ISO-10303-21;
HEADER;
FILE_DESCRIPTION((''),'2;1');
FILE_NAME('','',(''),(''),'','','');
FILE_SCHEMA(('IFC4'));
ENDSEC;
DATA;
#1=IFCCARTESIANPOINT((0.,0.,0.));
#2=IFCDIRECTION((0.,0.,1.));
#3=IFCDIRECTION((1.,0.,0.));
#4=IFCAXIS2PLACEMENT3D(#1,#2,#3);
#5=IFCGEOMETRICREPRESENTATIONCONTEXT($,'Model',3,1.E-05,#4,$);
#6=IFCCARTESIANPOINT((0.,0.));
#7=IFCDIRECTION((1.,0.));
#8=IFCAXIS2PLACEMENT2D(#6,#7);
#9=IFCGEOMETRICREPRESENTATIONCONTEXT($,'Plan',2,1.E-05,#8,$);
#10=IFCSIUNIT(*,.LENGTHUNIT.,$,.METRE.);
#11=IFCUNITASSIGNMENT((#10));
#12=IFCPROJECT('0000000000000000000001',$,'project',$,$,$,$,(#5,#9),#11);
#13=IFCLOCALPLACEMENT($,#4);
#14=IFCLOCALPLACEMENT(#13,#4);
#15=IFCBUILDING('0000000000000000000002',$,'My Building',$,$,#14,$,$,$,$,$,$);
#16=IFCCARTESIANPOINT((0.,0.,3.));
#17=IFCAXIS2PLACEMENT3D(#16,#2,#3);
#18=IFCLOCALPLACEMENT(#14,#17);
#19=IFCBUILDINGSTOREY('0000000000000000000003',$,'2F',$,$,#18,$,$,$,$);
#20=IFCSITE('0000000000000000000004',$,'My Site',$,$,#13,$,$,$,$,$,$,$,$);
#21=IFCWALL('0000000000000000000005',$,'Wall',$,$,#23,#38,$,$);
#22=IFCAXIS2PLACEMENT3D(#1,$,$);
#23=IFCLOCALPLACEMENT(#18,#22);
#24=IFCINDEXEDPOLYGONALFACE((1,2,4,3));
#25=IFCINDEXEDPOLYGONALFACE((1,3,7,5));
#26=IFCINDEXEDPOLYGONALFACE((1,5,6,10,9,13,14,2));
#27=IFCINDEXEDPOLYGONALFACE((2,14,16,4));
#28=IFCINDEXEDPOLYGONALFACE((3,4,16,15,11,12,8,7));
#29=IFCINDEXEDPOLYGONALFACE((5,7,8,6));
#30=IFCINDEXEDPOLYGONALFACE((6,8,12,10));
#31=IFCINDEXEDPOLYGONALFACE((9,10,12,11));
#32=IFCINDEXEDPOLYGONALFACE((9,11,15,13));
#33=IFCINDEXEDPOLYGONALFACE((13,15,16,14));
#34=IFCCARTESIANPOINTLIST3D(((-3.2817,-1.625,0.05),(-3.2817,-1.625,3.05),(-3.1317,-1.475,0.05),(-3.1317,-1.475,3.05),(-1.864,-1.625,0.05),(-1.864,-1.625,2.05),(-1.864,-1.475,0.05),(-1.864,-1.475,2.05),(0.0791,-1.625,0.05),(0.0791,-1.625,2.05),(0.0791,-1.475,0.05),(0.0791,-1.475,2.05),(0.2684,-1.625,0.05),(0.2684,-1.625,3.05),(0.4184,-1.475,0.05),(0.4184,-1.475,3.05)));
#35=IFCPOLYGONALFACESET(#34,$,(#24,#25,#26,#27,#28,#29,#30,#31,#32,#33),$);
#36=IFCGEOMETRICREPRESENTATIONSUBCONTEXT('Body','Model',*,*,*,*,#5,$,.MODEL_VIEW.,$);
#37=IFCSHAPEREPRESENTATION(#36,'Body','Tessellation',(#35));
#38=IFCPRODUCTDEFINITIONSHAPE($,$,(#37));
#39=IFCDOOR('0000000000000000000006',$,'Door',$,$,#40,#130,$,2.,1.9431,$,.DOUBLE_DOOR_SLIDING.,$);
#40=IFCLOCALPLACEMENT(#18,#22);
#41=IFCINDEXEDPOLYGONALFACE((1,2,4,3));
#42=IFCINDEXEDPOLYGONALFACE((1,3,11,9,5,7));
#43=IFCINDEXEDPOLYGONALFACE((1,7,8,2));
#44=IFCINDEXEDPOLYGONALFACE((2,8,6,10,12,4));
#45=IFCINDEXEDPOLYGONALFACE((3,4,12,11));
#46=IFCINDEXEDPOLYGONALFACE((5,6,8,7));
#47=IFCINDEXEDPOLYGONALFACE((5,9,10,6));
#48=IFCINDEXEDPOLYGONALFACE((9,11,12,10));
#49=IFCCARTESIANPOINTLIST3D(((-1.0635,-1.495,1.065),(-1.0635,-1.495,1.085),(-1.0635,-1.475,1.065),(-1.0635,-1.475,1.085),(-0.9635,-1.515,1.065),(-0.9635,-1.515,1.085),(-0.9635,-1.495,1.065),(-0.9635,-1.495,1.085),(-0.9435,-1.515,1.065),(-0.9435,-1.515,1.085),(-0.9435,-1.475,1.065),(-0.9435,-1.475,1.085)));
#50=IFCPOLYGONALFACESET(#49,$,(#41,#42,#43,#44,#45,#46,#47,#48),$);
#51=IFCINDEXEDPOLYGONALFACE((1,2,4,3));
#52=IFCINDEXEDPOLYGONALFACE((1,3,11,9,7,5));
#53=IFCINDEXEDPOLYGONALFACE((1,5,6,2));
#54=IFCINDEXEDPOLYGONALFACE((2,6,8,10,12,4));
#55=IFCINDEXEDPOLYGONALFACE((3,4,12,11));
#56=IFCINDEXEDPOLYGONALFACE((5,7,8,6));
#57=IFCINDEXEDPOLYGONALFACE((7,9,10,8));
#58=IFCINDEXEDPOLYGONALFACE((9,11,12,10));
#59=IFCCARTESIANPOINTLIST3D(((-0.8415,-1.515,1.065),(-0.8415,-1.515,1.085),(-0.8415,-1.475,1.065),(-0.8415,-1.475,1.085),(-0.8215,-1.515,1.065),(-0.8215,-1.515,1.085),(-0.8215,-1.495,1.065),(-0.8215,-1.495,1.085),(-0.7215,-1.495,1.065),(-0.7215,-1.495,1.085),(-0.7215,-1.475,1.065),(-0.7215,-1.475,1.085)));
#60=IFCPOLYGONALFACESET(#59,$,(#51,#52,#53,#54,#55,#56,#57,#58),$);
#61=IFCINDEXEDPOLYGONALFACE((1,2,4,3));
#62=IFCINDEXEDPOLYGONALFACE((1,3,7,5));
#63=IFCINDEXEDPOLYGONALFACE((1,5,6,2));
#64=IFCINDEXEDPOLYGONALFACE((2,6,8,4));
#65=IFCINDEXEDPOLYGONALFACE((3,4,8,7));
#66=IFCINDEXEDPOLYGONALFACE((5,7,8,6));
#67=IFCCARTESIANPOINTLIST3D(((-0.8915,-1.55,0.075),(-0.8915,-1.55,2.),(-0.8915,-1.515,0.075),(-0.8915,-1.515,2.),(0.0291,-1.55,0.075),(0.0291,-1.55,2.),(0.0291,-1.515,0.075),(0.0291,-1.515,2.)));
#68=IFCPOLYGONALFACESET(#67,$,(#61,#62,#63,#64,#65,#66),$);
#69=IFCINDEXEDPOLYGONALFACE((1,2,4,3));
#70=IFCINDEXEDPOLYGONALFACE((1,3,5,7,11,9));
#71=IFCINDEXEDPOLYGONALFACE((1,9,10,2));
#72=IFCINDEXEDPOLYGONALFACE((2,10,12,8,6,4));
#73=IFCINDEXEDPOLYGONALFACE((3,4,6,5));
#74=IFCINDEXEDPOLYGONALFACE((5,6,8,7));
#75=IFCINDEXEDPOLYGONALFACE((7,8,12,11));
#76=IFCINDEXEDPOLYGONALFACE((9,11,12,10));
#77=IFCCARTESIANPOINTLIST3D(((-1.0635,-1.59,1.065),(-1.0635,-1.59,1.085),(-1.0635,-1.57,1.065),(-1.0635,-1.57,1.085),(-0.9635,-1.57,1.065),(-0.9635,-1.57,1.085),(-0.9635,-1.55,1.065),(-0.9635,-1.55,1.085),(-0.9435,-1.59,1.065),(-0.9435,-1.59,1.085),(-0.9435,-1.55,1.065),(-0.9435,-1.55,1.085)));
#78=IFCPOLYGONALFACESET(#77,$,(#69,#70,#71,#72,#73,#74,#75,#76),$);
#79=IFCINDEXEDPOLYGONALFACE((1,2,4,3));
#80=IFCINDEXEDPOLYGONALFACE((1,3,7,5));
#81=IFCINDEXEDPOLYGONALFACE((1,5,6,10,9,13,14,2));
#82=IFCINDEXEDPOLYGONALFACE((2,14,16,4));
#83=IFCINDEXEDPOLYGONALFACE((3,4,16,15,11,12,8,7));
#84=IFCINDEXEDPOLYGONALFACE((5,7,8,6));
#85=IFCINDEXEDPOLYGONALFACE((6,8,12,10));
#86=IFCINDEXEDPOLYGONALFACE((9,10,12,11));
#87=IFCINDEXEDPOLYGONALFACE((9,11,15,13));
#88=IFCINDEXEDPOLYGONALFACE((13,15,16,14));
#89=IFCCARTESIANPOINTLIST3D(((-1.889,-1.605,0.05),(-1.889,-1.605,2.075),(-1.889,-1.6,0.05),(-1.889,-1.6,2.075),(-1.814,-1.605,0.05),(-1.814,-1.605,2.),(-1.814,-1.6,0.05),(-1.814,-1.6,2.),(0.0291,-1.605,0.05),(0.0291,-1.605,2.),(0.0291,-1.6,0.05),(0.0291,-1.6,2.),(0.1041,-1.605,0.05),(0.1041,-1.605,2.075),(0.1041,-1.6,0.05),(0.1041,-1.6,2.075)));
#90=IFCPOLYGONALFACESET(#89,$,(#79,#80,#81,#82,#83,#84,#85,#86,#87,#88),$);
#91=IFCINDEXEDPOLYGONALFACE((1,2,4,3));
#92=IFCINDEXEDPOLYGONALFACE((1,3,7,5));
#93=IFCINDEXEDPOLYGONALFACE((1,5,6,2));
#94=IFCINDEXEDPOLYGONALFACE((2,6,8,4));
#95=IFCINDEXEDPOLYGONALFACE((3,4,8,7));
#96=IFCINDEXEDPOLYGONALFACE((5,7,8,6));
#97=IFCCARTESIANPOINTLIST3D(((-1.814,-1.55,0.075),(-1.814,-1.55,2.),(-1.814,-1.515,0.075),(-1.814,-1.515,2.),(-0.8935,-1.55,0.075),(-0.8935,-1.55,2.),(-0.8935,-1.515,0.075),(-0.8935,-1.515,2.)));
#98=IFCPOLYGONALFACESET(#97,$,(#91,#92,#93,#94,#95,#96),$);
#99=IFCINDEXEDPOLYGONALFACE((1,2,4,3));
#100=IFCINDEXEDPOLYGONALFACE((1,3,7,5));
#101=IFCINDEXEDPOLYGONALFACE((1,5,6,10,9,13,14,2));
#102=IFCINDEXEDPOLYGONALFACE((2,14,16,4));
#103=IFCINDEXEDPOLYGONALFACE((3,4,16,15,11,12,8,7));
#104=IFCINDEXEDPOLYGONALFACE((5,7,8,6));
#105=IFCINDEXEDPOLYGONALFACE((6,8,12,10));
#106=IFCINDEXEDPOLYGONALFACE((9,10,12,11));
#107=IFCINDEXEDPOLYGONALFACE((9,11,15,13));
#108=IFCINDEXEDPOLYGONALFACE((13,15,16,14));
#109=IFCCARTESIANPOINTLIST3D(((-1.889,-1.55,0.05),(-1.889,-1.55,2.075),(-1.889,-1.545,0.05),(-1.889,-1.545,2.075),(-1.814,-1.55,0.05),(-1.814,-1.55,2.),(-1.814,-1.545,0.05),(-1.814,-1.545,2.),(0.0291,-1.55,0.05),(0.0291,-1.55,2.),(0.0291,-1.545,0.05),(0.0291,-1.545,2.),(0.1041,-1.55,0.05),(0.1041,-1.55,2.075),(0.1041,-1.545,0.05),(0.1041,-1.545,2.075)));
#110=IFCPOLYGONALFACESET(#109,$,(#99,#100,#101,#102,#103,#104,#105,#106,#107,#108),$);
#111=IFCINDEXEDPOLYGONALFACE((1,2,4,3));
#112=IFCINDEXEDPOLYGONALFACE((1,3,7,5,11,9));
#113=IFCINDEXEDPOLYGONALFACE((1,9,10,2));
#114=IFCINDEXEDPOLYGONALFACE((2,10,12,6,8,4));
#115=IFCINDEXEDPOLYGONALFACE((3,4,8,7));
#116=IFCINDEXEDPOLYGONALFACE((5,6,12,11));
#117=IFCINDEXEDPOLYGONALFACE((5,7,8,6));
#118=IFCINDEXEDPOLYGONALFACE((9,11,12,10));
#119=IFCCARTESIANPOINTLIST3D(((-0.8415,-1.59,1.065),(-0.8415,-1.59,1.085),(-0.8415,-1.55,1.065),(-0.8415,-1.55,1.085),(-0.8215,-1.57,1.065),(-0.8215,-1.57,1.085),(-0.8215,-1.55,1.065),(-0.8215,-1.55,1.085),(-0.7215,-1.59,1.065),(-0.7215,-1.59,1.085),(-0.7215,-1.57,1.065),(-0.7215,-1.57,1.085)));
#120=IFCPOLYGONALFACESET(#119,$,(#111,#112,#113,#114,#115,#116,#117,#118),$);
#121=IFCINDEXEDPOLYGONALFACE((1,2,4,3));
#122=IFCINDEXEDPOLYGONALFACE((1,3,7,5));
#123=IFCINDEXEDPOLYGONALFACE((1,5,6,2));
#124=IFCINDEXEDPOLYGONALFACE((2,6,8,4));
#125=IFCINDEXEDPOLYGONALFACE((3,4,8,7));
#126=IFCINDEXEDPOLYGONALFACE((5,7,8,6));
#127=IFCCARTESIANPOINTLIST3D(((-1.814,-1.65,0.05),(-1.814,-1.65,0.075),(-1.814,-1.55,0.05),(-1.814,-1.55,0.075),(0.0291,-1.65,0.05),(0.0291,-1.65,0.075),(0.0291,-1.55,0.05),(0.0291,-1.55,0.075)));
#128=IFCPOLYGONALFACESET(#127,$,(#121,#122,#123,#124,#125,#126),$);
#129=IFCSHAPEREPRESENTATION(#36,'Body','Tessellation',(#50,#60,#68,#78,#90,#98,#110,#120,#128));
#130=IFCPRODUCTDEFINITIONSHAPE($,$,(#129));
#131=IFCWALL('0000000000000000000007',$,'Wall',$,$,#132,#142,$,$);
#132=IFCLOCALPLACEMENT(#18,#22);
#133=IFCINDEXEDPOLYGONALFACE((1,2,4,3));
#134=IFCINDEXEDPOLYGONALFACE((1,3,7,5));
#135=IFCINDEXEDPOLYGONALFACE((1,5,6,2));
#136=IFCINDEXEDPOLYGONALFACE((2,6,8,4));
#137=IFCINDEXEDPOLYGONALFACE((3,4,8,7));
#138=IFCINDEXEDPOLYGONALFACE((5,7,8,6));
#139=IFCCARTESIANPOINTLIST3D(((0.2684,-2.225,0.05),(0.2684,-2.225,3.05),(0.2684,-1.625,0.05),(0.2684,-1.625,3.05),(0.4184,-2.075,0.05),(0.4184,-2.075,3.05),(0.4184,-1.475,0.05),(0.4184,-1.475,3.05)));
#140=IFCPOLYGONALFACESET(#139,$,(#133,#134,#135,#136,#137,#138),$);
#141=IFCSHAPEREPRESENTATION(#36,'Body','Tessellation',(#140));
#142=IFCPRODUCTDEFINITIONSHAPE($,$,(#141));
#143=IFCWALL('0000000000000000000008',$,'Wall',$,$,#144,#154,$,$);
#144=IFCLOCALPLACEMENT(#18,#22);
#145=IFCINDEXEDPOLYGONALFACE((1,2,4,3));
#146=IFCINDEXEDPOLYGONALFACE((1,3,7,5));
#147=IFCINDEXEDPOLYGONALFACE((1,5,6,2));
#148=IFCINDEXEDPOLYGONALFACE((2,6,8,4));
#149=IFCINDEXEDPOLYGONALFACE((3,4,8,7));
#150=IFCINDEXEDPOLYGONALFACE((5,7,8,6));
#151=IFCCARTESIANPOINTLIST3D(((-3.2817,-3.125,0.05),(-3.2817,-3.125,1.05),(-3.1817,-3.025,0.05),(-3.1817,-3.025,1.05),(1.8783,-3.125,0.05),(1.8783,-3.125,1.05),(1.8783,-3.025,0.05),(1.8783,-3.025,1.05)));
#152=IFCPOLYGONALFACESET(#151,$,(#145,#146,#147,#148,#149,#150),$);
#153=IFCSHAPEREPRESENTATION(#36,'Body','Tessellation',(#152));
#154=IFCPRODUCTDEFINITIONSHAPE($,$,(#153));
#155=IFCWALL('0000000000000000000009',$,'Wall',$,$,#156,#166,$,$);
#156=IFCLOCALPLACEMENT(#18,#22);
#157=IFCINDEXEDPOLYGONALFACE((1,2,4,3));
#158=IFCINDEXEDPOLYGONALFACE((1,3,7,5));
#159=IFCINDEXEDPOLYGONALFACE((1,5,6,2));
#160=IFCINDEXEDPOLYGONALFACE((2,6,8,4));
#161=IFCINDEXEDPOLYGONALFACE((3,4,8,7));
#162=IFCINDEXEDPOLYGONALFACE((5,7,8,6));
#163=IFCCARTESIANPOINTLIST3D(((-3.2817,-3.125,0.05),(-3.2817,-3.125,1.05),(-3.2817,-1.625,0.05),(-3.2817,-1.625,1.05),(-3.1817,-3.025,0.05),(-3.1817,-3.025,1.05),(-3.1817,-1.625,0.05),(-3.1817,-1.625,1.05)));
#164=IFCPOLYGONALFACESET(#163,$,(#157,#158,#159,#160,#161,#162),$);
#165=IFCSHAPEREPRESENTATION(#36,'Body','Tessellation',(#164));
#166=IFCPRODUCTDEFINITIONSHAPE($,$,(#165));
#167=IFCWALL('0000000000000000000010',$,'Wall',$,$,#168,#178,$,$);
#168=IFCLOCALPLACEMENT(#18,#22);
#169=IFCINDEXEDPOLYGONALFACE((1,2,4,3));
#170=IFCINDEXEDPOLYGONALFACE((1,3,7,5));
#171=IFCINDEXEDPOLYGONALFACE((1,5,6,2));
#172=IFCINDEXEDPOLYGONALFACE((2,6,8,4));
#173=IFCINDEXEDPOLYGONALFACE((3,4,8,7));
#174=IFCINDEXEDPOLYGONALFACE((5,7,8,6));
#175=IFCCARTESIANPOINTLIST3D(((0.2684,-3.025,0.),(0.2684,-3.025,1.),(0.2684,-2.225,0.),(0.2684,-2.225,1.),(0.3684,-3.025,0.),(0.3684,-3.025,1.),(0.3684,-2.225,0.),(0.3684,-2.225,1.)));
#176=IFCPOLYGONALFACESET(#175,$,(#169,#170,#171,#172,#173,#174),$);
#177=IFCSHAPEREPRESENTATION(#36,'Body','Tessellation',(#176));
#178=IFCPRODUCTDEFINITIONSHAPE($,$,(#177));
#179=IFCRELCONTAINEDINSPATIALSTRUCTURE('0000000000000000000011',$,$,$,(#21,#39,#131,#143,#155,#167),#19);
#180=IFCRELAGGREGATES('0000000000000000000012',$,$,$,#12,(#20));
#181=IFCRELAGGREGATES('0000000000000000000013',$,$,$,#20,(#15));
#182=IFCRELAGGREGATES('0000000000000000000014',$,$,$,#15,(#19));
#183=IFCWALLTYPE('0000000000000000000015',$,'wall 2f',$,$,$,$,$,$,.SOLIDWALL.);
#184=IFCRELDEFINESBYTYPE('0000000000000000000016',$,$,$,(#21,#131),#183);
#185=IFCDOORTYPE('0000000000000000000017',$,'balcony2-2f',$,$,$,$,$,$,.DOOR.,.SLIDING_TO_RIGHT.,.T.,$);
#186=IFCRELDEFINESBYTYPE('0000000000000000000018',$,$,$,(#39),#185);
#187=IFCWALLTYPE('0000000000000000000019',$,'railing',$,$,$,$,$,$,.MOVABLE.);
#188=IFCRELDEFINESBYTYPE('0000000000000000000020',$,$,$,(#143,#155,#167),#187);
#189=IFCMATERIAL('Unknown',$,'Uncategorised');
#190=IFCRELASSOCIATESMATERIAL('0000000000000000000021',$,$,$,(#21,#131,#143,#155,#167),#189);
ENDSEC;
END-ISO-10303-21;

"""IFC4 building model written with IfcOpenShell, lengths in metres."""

from ifc_helpers import new_model, entity, si_unit, frame, origin_with_axes, origin_2d_with_axis, place, context, subcontext, project, spatial, line, indexed_curve, outline, extrude, shape, source, transform, mapped, material, type_object, type_shapes, element, fill, save


model = new_model("IFC4")

# Units and contexts
model_context = context("Model", 3, precision=1e-05, world=origin_with_axes())
plan_context = context("Plan", 2, precision=1e-05, world=origin_2d_with_axis())
body_context_1 = subcontext(model_context, "Body", "Model", "MODEL_VIEW")
body_context_2 = subcontext(plan_context, "Body", "Plan", "PLAN_VIEW")
ifc_project = project(units=[si_unit("LENGTHUNIT", "METRE")], contexts=[model_context, plan_context])

# Site, building, storey
site_placement = place(None, origin_with_axes())
site = spatial("IfcSite", under=ifc_project, at=site_placement, Name="My Site")
building_placement = place(site_placement, origin_with_axes())
building = spatial("IfcBuilding", under=site, at=building_placement, Name="My Building")
storey_placement = place(building_placement, frame((0.0, 0.0, 3.0), z_axis=(0.0, 0.0, 1.0), x_axis=(1.0, 0.0, 0.0)))
storey = spatial("IfcBuildingStorey", under=building, at=storey_placement, Name="2F")

# Shared definitions
ifc_material = material(Name="Unknown", Category="Uncategorised")

# Shared definitions
wall_type_1 = type_object("IfcWallType", Name="wall 2f", PredefinedType="SOLIDWALL")

# Wall, opening, door
wall_1_placement = place(storey_placement, frame((-3.2817, -1.625, 0.05), z_axis=(0.0, 0.0, 1.0), x_axis=(1.0, 0.0, 0.0)))
wall_1 = element("IfcWall", 1, at=wall_1_placement, inside=storey, type_object=wall_type_1, material=ifc_material, Name="Wall", context=body_context_1, shape_type="SweptSolid", body=[
    extrude(outline(indexed_curve([(0.0, 0.0), (0.15, 0.15), (3.7, 0.15), (3.55, 0.0)], segments=[line(1, 2, 3, 4, 1)])), origin_with_axes(), (0.0, 0.0, 1.0), 3.0),
])
shared_shape_1 = source(origin_with_axes(), body_context_1, "Body", "SweptSolid", [
    extrude(outline(indexed_curve([(0.0, 0.0), (1.9431, 0.0), (1.9431, 2.0), (0.0, 2.0)], segments=[line(1, 2, 3, 4, 1)])), frame((0.0, -0.6, 0.0), z_axis=(0.0, -1.0, 0.0), x_axis=(1.0, 0.0, 0.0)), (0.0, 0.0, -1.0), 1.2),
])
opening_1_placement = place(wall_1_placement, frame((3.3607, 0.075, 0.0), z_axis=(0.0, 0.0, 1.0), x_axis=(-1.0, 0.0, 0.0)))
opening_1 = element("IfcOpeningElement", 2, at=opening_1_placement, cuts=wall_1, PredefinedType="OPENING", context=body_context_1, shape_type="MappedRepresentation", body=[
    mapped(shared_shape_1, transform((0.0, 0.0, 0.0), x_axis=(1.0, 0.0, 0.0), y_axis=(0.0, 1.0, 0.0), z_axis=(0.0, 0.0, 1.0), scale=1.0)),
])
door_type_1 = type_object("IfcDoorType", Name="balcony2-2f", OperationType="SLIDING_TO_RIGHT", ParameterTakesPrecedence=True, PredefinedType="DOOR")
shared_shape_2 = source(origin_with_axes(), body_context_1, "Body", "SweptSolid", [
    extrude(outline(indexed_curve([(0.0, 0.0), (0.0, -0.04), (0.12, -0.04), (0.12, -0.02), (0.02, -0.02), (0.02, 0.0)], segments=[line(1, 2, 3, 4, 5, 6, 1)])), frame((1.0225, -0.035, 1.015), z_axis=(0.0, 0.0, 1.0), x_axis=(1.0, 0.0, 0.0)), (0.0, 0.0, 1.0), 0.02),
    extrude(outline(indexed_curve([(0.0, 0.0), (0.0, -0.04), (-0.12, -0.04), (-0.12, -0.02), (-0.02, -0.02), (-0.02, 0.0)], segments=[line(1, 2, 3, 4, 5, 6, 1)])), frame((0.9205, -0.035, 1.015), z_axis=(0.0, 0.0, 1.0), x_axis=(1.0, 0.0, 0.0)), (0.0, 0.0, 1.0), 0.02),
    extrude(outline(indexed_curve([(0.0, 0.0), (0.9205, 0.0), (0.9205, 0.035), (0.0, 0.035)], segments=[line(1, 2, 3, 4, 1)])), frame((0.05, -0.035, 0.025), z_axis=(0.0, 0.0, 1.0), x_axis=(1.0, 0.0, 0.0)), (0.0, 0.0, 1.0), 1.925),
    extrude(outline(indexed_curve([(0.0, 0.0), (0.0, 0.04), (0.12, 0.04), (0.12, 0.02), (0.02, 0.02), (0.02, 0.0)], segments=[line(1, 2, 3, 4, 5, 6, 1)])), frame((1.0225, 0.0, 1.015), z_axis=(0.0, 0.0, 1.0), x_axis=(1.0, 0.0, 0.0)), (0.0, 0.0, 1.0), 0.02),
    extrude(outline(indexed_curve([(0.0, 0.0), (0.0, 2.025), (1.9931, 2.025), (1.9931, 0.0), (1.9181, 0.0), (1.9181, 1.95), (0.075, 1.95), (0.075, 0.0)], segments=[line(1, 2, 3, 4, 5, 6, 7, 8, 1)])), frame((-0.025, 0.05, 0.0), z_axis=(0.0, -1.0, 0.0), x_axis=(1.0, 0.0, 0.0)), (0.0, 0.0, -1.0), 0.005),
    extrude(outline(indexed_curve([(0.0, 0.0), (-0.9205, 0.0), (-0.9205, 0.035), (0.0, 0.035)], segments=[line(1, 2, 3, 4, 1)])), frame((1.8931, -0.035, 0.025), z_axis=(0.0, 0.0, 1.0), x_axis=(1.0, 0.0, 0.0)), (0.0, 0.0, 1.0), 1.925),
    extrude(outline(indexed_curve([(0.0, 0.0), (0.0, 2.025), (1.9931, 2.025), (1.9931, 0.0), (1.9181, 0.0), (1.9181, 1.95), (0.075, 1.95), (0.075, 0.0)], segments=[line(1, 2, 3, 4, 5, 6, 7, 8, 1)])), frame((-0.025, -0.005, 0.0), z_axis=(0.0, -1.0, 0.0), x_axis=(1.0, 0.0, 0.0)), (0.0, 0.0, -1.0), 0.005),
    extrude(outline(indexed_curve([(0.0, 0.0), (0.0, 0.04), (-0.12, 0.04), (-0.12, 0.02), (-0.02, 0.02), (-0.02, 0.0)], segments=[line(1, 2, 3, 4, 5, 6, 1)])), frame((0.9205, 0.0, 1.015), z_axis=(0.0, 0.0, 1.0), x_axis=(1.0, 0.0, 0.0)), (0.0, 0.0, 1.0), 0.02),
    extrude(outline(indexed_curve([(0.0, 0.0), (1.8431, 0.0), (1.8431, 0.1), (0.0, 0.1)], segments=[line(1, 2, 3, 4, 1)])), frame((0.05, 0.0, 0.0), z_axis=(0.0, 0.0, 1.0), x_axis=(1.0, 0.0, 0.0)), (0.0, 0.0, 1.0), 0.025),
])
shared_shape_3 = source(origin_with_axes(), body_context_2, "Body", "Curve2D", [
    entity("IfcIndexedPolyCurve", entity("IfcCartesianPointList2D", [[0.0, 0.0], [0.05, 0.0], [0.05, 0.05], [0.0, 0.05]]), [entity("IfcLineIndex", [1, 2, 3, 4, 1])]),
    entity("IfcIndexedPolyCurve", entity("IfcCartesianPointList2D", [[1.9431, 0.0], [1.8931, 0.0], [1.8931, 0.05], [1.9431, 0.05]]), [entity("IfcLineIndex", [1, 2, 3, 4, 1])]),
    entity("IfcIndexedPolyCurve", entity("IfcCartesianPointList2D", [[-0.4108, -0.035], [0.5108, -0.035], [0.5108, 0.0], [-0.4108, 0.0]]), [entity("IfcLineIndex", [1, 2, 3, 4, 1])]),
    entity("IfcIndexedPolyCurve", entity("IfcCartesianPointList2D", [[2.3538, -0.035], [1.4323, -0.035], [1.4323, 0.0], [2.3538, 0.0]]), [entity("IfcLineIndex", [1, 2, 3, 4, 1])]),
])
type_shapes(door_type_1, [shared_shape_2, shared_shape_3])
door_1_placement = place(opening_1_placement, origin_with_axes())
door_1 = element("IfcDoor", 3, at=door_1_placement, inside=storey, type_object=door_type_1, Name="Door", OperationType="DOUBLE_DOOR_SLIDING", OverallHeight=2.0, OverallWidth=1.9431, shapes=[
    shape(body_context_1, "Body", "MappedRepresentation", [mapped(shared_shape_2, transform((0.0, 0.0, 0.0), x_axis=(1.0, 0.0, 0.0), y_axis=(0.0, 1.0, 0.0), z_axis=(0.0, 0.0, 1.0), scale=1.0))]),
    shape(body_context_2, "Body", "MappedRepresentation", [mapped(shared_shape_3, transform((0.0, 0.0, 0.0), x_axis=(1.0, 0.0, 0.0), y_axis=(0.0, 1.0, 0.0), z_axis=(0.0, 0.0, 1.0), scale=1.0))]),
])
fill(opening_1, door_1)

# Walls
wall_2_placement = place(storey_placement, frame((0.2684, -1.625, 0.05), z_axis=(0.0, 0.0, 1.0), x_axis=(0.0, -1.0, 0.0)))
element("IfcWall", 4, at=wall_2_placement, inside=storey, type_object=wall_type_1, material=ifc_material, Name="Wall", context=body_context_1, shape_type="SweptSolid", body=[
    extrude(outline(indexed_curve([(0.0, 0.0), (-0.15, 0.15), (0.45, 0.15), (0.6, 0.0)], segments=[line(1, 2, 3, 4, 1)])), origin_with_axes(), (0.0, 0.0, 1.0), 3.0),
])
wall_type_2 = type_object("IfcWallType", Name="railing", PredefinedType="MOVABLE")
wall_3_placement = place(storey_placement, frame((1.8783, -3.025, 0.05), z_axis=(0.0, 0.0, 1.0), x_axis=(-1.0, 0.0, 0.0)))
element("IfcWall", 5, at=wall_3_placement, inside=storey, type_object=wall_type_2, material=ifc_material, Name="Wall", context=body_context_1, shape_type="SweptSolid", body=[
    extrude(outline(indexed_curve([(0.0, 0.0), (0.0, 0.1), (5.16, 0.1), (5.06, 0.0)], segments=[line(1, 2, 3, 4, 1)])), origin_with_axes(), (0.0, 0.0, 1.0), 1.0),
])
wall_4_placement = place(storey_placement, frame((-3.2817, -1.625, 0.05), z_axis=(0.0, 0.0, 1.0), x_axis=(0.0, -1.0, 0.0)))
element("IfcWall", 6, at=wall_4_placement, inside=storey, type_object=wall_type_2, material=ifc_material, Name="Wall", context=body_context_1, shape_type="SweptSolid", body=[
    extrude(outline(indexed_curve([(0.0, 0.0), (0.0, 0.1), (1.4, 0.1), (1.5, 0.0)], segments=[line(1, 2, 3, 4, 1)])), origin_with_axes(), (0.0, 0.0, 1.0), 1.0),
])
wall_5_placement = place(storey_placement, frame((0.2684, -2.225, 0.0), z_axis=(0.0, 0.0, 1.0), x_axis=(0.0, -1.0, 0.0)))
element("IfcWall", 7, at=wall_5_placement, inside=storey, type_object=wall_type_2, material=ifc_material, Name="Wall", context=body_context_1, shape_type="SweptSolid", body=[
    extrude(outline(indexed_curve([(0.0, 0.0), (0.0, 0.1), (0.8, 0.1), (0.8, 0.0)], segments=[line(1, 2, 3, 4, 1)])), origin_with_axes(), (0.0, 0.0, 1.0), 1.0),
])

save(model, "model.ifc")
